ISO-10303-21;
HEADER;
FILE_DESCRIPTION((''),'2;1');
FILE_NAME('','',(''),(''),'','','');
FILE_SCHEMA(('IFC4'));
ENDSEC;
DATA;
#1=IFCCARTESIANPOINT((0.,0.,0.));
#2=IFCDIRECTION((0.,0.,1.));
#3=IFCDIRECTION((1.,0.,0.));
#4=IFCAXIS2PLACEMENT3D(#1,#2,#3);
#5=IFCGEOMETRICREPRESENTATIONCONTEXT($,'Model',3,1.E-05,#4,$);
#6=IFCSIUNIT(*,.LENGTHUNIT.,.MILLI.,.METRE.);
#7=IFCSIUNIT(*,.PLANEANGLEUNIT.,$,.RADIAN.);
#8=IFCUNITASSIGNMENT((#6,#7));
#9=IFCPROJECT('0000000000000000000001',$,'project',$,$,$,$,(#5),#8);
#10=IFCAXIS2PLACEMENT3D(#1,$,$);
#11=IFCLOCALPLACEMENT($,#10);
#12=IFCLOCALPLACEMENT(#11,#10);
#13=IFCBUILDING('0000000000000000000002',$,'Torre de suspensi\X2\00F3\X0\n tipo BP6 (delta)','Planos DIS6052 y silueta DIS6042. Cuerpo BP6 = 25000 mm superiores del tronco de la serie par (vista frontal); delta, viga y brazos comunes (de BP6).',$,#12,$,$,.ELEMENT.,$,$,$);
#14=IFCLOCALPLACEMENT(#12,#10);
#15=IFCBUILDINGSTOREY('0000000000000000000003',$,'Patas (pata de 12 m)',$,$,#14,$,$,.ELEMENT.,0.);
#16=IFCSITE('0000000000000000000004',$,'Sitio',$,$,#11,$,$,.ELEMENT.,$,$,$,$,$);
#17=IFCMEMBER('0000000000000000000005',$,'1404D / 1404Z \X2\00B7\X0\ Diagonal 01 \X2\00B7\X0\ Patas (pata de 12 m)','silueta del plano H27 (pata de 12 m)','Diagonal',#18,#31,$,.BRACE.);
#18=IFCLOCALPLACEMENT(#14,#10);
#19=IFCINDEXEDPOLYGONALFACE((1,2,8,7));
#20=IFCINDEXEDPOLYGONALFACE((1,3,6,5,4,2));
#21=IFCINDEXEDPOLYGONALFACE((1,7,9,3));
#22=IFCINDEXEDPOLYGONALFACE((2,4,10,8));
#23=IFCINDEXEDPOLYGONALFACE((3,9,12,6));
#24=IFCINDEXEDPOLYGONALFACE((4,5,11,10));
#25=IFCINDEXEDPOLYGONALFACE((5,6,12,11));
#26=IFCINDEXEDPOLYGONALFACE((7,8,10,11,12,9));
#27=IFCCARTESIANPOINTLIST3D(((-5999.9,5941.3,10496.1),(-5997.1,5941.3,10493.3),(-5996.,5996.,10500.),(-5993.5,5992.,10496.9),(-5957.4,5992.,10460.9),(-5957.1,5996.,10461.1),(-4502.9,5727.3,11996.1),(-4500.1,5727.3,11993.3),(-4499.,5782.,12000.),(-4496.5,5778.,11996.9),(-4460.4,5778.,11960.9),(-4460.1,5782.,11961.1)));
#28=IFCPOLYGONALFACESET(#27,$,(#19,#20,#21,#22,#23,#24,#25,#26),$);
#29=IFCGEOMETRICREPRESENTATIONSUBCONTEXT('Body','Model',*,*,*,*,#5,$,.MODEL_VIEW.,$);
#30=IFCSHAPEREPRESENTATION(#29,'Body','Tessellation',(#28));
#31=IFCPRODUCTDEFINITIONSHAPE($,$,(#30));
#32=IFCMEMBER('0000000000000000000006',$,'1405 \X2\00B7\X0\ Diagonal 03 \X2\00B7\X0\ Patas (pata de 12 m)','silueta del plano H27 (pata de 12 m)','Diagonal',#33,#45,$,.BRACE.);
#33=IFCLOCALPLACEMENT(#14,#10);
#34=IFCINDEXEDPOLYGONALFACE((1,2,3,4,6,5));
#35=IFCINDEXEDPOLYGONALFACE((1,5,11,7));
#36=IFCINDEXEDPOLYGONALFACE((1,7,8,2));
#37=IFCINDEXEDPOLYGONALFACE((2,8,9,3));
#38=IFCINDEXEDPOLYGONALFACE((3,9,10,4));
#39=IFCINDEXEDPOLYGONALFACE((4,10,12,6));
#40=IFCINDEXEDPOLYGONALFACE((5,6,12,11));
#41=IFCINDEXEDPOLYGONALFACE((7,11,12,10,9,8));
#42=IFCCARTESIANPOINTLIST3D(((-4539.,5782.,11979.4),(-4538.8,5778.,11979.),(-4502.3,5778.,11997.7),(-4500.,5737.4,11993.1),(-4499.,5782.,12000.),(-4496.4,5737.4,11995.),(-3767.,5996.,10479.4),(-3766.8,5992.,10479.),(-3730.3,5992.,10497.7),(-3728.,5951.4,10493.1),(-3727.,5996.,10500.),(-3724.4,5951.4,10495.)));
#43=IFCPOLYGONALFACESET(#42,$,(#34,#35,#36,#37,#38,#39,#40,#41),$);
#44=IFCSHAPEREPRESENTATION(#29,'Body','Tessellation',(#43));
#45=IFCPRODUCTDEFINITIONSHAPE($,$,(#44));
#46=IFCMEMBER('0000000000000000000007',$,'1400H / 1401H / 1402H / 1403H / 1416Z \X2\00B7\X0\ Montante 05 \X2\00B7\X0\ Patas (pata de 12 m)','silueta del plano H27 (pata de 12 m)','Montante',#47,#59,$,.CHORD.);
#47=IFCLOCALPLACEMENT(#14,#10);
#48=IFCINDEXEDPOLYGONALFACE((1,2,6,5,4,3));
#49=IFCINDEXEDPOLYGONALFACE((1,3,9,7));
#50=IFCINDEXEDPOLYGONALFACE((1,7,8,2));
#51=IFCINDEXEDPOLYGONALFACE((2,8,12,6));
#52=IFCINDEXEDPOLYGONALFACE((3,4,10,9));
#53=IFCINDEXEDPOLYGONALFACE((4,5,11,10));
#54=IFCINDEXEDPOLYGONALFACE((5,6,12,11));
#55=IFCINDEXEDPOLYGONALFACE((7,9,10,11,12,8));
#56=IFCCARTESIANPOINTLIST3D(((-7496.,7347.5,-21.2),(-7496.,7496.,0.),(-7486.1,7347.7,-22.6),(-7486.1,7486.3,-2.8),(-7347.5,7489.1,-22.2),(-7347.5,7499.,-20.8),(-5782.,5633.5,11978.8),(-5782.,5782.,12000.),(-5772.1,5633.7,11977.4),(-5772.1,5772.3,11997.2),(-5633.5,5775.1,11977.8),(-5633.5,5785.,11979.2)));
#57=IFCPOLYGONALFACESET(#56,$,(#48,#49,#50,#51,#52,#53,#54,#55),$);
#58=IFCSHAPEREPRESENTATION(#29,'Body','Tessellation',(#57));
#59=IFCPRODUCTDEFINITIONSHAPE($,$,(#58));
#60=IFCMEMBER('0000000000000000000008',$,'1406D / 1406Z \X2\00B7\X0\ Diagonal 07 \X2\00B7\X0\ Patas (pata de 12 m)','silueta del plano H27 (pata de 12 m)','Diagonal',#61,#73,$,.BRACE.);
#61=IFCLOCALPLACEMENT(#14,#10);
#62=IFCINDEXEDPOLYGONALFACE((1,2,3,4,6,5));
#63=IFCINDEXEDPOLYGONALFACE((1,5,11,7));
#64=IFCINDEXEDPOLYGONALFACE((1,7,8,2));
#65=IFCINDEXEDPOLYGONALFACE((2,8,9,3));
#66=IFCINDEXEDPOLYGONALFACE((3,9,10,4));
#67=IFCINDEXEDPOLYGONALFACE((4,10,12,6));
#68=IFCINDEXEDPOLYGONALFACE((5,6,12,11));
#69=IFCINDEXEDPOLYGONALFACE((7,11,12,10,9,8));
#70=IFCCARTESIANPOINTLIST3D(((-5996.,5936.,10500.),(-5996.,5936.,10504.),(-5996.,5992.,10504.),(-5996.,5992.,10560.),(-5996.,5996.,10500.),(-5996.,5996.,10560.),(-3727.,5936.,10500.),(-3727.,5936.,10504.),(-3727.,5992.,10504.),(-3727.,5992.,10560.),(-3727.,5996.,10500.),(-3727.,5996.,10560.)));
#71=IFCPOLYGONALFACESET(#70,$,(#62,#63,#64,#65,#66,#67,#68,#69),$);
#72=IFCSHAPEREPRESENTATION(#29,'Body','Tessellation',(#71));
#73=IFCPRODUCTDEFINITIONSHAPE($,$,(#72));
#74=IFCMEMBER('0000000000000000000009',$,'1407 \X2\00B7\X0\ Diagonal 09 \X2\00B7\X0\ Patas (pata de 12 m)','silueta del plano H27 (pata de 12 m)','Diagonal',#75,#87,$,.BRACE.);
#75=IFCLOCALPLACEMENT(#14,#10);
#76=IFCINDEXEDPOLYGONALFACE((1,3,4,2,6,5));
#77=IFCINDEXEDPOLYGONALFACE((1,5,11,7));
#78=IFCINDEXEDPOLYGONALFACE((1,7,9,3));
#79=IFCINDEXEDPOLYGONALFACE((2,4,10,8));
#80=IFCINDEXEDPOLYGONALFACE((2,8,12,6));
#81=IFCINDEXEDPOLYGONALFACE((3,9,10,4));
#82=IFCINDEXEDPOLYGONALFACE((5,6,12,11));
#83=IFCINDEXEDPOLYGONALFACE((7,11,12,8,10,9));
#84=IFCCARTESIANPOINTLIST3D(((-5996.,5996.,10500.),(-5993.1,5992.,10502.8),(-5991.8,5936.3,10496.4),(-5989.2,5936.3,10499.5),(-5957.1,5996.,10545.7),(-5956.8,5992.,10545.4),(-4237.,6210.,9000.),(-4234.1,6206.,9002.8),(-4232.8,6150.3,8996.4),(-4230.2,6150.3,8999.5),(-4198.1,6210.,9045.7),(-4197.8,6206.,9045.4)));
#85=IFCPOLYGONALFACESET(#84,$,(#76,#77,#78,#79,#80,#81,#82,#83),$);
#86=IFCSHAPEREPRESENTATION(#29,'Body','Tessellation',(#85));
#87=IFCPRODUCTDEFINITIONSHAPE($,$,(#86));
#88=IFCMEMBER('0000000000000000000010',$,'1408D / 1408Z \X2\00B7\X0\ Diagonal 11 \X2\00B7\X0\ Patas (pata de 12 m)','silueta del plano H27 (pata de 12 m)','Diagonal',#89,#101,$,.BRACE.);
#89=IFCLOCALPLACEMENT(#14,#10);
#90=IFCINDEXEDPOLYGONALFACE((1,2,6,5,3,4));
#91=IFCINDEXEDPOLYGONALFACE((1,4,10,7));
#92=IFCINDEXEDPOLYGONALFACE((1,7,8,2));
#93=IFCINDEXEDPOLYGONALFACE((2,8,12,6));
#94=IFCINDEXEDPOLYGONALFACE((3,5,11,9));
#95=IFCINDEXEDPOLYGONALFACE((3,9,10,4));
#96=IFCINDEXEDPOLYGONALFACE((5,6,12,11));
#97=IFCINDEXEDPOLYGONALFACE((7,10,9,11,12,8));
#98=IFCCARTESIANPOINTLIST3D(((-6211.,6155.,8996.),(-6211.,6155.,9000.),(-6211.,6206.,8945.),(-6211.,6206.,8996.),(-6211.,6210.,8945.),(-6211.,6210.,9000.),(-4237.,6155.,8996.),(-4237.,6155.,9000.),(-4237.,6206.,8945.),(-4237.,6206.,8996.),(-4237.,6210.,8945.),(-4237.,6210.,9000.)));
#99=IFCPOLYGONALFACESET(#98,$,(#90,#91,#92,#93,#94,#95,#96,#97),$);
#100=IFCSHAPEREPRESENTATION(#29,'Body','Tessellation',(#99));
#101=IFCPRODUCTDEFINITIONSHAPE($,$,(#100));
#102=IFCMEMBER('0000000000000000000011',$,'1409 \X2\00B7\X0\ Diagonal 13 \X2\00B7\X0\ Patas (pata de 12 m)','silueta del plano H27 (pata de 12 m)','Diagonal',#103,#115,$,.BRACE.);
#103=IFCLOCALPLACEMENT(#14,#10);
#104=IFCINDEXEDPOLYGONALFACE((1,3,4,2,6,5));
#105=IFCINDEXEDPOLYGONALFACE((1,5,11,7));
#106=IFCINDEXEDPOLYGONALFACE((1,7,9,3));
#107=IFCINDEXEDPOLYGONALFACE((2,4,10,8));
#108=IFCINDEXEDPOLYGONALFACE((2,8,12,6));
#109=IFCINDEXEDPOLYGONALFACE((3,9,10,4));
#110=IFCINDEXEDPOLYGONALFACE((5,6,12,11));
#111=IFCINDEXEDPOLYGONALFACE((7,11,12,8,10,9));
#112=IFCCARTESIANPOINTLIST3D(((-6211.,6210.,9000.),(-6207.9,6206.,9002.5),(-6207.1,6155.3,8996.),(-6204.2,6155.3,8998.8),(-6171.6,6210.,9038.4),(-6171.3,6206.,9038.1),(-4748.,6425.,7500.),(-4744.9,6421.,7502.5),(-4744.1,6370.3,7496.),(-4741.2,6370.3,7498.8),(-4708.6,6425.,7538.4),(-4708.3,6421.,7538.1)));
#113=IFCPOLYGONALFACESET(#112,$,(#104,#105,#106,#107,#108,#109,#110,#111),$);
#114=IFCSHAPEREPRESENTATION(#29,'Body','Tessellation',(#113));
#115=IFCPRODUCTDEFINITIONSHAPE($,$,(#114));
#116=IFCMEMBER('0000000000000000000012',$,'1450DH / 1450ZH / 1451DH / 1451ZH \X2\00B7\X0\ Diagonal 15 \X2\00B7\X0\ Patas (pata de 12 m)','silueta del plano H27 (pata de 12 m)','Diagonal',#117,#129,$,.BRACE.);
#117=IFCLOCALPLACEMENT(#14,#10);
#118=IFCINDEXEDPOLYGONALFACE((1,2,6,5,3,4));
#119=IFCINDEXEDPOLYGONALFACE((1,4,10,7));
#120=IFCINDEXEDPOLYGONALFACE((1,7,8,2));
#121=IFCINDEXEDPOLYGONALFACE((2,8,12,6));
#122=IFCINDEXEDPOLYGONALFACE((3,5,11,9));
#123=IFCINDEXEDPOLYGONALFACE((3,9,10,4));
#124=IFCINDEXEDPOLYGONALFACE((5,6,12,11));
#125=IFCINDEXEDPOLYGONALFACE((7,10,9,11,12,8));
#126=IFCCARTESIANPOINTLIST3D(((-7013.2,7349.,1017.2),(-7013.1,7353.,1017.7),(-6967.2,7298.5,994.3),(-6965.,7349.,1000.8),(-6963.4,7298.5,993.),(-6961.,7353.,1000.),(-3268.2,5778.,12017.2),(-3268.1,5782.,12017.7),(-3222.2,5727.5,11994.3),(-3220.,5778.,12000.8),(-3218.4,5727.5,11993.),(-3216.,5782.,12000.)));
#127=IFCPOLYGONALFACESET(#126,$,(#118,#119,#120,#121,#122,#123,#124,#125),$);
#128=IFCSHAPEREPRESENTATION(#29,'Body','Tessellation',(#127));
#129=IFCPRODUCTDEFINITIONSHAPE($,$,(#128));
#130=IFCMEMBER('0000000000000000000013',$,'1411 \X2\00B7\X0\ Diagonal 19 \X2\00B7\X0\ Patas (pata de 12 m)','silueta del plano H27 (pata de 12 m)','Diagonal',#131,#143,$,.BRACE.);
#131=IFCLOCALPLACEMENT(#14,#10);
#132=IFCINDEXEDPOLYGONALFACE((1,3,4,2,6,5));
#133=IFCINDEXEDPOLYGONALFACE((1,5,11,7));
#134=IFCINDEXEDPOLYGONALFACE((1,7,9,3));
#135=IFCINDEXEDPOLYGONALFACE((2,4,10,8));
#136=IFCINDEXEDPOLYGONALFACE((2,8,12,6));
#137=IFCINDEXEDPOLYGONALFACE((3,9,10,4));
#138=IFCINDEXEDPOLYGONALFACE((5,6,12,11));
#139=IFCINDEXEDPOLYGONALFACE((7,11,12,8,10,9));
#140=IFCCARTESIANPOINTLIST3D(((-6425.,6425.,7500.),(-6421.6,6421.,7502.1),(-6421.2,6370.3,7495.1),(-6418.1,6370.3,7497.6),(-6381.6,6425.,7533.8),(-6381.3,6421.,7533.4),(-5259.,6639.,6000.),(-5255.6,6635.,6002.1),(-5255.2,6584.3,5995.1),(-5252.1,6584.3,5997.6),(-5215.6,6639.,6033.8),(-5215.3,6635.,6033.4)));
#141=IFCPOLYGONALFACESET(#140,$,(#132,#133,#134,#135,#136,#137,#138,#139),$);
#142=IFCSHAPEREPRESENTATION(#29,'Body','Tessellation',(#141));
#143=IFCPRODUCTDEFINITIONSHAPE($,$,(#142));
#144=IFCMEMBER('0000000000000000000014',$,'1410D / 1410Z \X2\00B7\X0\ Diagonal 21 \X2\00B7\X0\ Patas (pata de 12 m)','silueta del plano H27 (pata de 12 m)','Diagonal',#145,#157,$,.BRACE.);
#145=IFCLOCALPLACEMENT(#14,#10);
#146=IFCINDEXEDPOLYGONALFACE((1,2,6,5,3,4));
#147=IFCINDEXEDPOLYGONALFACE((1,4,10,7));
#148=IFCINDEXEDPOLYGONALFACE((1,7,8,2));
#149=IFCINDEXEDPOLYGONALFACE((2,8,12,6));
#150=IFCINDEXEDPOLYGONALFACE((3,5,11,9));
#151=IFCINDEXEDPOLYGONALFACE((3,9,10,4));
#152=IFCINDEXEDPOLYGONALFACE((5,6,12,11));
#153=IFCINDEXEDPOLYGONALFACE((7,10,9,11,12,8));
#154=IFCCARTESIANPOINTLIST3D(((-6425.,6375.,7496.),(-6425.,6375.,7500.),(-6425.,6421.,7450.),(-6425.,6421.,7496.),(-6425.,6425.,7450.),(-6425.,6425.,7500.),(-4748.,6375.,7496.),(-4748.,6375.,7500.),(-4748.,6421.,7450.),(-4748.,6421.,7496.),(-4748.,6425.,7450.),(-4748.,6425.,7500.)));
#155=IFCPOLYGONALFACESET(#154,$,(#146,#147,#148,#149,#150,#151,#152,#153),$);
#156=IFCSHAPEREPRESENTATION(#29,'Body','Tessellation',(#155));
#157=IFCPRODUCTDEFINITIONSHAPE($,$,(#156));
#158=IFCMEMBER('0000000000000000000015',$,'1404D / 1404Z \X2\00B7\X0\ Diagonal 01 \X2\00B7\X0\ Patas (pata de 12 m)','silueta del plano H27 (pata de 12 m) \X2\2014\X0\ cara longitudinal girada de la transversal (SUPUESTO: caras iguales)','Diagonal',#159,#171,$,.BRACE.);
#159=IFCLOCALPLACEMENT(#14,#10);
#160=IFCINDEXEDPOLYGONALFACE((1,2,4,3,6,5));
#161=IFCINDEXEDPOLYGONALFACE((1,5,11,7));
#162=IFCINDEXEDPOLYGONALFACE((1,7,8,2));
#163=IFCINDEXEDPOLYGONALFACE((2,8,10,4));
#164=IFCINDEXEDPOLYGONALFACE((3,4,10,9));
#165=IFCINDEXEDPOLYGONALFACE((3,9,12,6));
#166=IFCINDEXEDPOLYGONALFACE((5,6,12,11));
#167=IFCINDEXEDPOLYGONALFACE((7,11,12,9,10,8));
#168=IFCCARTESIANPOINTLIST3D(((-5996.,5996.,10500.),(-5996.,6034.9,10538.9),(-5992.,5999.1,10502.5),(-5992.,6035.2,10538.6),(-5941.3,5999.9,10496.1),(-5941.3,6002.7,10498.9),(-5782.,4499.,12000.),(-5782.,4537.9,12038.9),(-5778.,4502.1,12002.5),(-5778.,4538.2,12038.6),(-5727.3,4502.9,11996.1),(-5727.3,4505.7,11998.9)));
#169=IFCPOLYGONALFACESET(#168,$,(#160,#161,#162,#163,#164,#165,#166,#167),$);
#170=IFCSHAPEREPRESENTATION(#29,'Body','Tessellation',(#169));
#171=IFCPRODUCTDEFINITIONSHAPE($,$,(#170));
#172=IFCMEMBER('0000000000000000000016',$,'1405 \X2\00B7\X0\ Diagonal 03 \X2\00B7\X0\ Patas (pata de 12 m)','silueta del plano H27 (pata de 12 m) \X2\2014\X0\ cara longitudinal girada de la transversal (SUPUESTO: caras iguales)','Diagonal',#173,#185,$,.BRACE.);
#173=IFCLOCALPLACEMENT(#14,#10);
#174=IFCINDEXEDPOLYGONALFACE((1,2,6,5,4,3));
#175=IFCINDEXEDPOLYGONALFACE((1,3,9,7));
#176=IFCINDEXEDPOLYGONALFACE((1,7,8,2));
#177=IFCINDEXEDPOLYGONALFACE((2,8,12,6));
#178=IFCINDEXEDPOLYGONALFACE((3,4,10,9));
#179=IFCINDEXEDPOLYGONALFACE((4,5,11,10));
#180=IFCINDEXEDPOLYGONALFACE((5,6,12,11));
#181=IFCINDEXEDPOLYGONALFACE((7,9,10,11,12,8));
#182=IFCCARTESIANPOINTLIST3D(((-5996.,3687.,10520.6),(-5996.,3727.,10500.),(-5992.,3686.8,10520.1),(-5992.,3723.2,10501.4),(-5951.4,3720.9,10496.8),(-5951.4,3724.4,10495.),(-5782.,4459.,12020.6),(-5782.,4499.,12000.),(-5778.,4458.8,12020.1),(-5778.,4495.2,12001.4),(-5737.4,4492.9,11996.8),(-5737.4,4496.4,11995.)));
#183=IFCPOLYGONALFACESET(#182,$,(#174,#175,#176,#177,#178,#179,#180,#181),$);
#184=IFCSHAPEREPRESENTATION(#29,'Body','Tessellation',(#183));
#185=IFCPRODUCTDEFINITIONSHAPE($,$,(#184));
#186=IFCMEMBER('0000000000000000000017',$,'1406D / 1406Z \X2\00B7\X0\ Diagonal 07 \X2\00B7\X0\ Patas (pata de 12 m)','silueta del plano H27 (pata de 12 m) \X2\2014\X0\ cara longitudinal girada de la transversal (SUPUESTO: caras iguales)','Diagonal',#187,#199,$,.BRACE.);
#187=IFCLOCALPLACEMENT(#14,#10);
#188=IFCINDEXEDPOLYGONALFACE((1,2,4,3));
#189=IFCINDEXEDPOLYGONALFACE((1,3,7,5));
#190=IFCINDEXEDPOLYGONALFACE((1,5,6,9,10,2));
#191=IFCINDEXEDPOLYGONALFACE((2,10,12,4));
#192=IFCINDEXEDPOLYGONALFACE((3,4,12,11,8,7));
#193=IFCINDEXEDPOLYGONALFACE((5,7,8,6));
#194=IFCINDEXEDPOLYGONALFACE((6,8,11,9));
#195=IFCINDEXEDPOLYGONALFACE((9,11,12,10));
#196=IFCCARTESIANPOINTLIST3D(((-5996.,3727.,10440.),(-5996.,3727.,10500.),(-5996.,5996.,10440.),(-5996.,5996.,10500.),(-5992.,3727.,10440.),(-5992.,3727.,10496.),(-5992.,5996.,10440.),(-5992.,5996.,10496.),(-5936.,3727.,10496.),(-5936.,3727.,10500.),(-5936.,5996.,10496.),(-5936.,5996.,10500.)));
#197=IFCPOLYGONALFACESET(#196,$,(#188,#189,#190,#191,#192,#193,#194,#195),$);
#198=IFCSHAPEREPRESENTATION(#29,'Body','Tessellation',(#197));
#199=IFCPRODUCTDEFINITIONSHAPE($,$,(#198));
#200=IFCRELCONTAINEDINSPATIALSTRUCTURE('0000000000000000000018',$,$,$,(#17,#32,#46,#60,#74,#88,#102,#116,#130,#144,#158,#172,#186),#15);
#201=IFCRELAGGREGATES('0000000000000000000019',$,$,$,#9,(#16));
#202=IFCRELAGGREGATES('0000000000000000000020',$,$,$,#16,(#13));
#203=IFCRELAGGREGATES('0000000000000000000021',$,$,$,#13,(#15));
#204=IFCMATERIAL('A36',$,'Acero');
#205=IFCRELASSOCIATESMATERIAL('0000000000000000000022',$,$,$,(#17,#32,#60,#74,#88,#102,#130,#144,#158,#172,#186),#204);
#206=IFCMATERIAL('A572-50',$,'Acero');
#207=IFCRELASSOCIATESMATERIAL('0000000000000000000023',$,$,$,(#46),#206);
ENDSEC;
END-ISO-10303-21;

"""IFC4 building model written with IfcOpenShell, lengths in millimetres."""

from ifc_helpers import new_model, si_unit, frame, frame_2d, origin, origin_with_axes, place, context, subcontext, project, spatial, l_section, extrude, material, element, save


model = new_model("IFC4")

# Units and contexts
model_context = context("Model", 3, precision=1e-05, world=origin_with_axes())
body_context = subcontext(model_context, "Body", "Model", "MODEL_VIEW")
ifc_project = project(units=[si_unit("LENGTHUNIT", "METRE", prefix="MILLI"), si_unit("PLANEANGLEUNIT", "RADIAN")], contexts=[model_context])

# Site, building, storey
site_placement = place(None, origin())
site = spatial("IfcSite", under=ifc_project, at=site_placement, Name="Sitio", CompositionType="ELEMENT")
building_placement = place(site_placement, origin())
building = spatial("IfcBuilding", under=site, at=building_placement, Name="Torre de suspensión tipo BP6 (delta)", Description="Planos DIS6052 y silueta DIS6042. Cuerpo BP6 = 25000 mm superiores del tronco de la serie par (vista frontal); delta, viga y brazos comunes (de BP6).", CompositionType="ELEMENT")
storey_placement = place(building_placement, origin())
storey = spatial("IfcBuildingStorey", under=building, at=storey_placement, Name="Patas (pata de 12 m)", CompositionType="ELEMENT", Elevation=0.0)

# Members
ifc_material_1 = material(Name="A36", Category="Acero")
member_1_placement = place(storey_placement, frame((-5996.0, 5996.0, 10500.0), z_axis=(0.702824, -0.100471, 0.704233), x_axis=(-0.070972, -0.99494, -0.071114)))
element("IfcMember", 1, at=member_1_placement, inside=storey, material=ifc_material_1, Name="1404D / 1404Z · Diagonal 01 · Patas (pata de 12 m)", Description="silueta del plano H27 (pata de 12 m)", ObjectType="Diagonal", PredefinedType="BRACE", context=body_context, shape_type="SweptSolid", body=[
    extrude(l_section(Depth=55.0, Width=55.0, Thickness=4.0, at=frame_2d((27.5, 27.5))), None, (0.0, 0.0, 1.0), 2130.0),
])
member_2_placement = place(storey_placement, frame((-4499.0, 5782.0, 12000.0), z_axis=(0.453978, 0.125844, -0.882081), x_axis=(0.057588, -0.99205, -0.111894)))
element("IfcMember", 2, at=member_2_placement, inside=storey, material=ifc_material_1, Name="1405 · Diagonal 03 · Patas (pata de 12 m)", Description="silueta del plano H27 (pata de 12 m)", ObjectType="Diagonal", PredefinedType="BRACE", context=body_context, shape_type="SweptSolid", body=[
    extrude(l_section(Depth=45.0, Width=45.0, Thickness=4.0, at=frame_2d((22.5, 22.5))), None, (0.0, 0.0, 1.0), 1700.5),
])
ifc_material_2 = material(Name="A572-50", Category="Acero")
member_3_placement = place(storey_placement, frame((-5782.0, 5782.0, 12000.0), z_axis=(-0.140006, 0.140006, -0.980202), x_axis=(0.990151, 0.019797, -0.138599)))
element("IfcMember", 3, at=member_3_placement, inside=storey, material=ifc_material_2, Name="1400H / 1401H / 1402H / 1403H / 1416Z · Montante 05 · Patas (pata de 12 m)", Description="silueta del plano H27 (pata de 12 m)", ObjectType="Montante", PredefinedType="CHORD", context=body_context, shape_type="SweptSolid", body=[
    extrude(l_section(Depth=150.0, Width=150.0, Thickness=10.0, at=frame_2d((75.0, 75.0))), None, (0.0, 0.0, 1.0), 12242.4),
])
member_4_placement = place(storey_placement, frame((-3727.0, 5996.0, 10500.0), z_axis=(-1.0, 0.0, 0.0), x_axis=(0.0, -1.0, 0.0)))
element("IfcMember", 4, at=member_4_placement, inside=storey, material=ifc_material_1, Name="1406D / 1406Z · Diagonal 07 · Patas (pata de 12 m)", Description="silueta del plano H27 (pata de 12 m)", ObjectType="Diagonal", PredefinedType="BRACE", context=body_context, shape_type="SweptSolid", body=[
    extrude(l_section(Depth=60.0, Width=60.0, Thickness=4.0, at=frame_2d((30.0, 30.0))), None, (0.0, 0.0, 1.0), 2269.0),
])
member_5_placement = place(storey_placement, frame((-4237.0, 6210.0, 9000.0), z_axis=(-0.757664, -0.092177, 0.646103), x_axis=(0.070138, -0.995743, -0.059811)))
element("IfcMember", 5, at=member_5_placement, inside=storey, material=ifc_material_1, Name="1407 · Diagonal 09 · Patas (pata de 12 m)", Description="silueta del plano H27 (pata de 12 m)", ObjectType="Diagonal", PredefinedType="BRACE", context=body_context, shape_type="SweptSolid", body=[
    extrude(l_section(Depth=60.0, Width=60.0, Thickness=4.0, at=frame_2d((30.0, 30.0))), None, (0.0, 0.0, 1.0), 2321.6),
])
member_6_placement = place(storey_placement, frame((-6211.0, 6210.0, 9000.0), z_axis=(1.0, 0.0, 0.0), x_axis=(0.0, -1.0, 0.0)))
element("IfcMember", 6, at=member_6_placement, inside=storey, material=ifc_material_1, Name="1408D / 1408Z · Diagonal 11 · Patas (pata de 12 m)", Description="silueta del plano H27 (pata de 12 m)", ObjectType="Diagonal", PredefinedType="BRACE", context=body_context, shape_type="SweptSolid", body=[
    extrude(l_section(Depth=55.0, Width=55.0, Thickness=4.0, at=frame_2d((27.5, 27.5))), None, (0.0, 0.0, 1.0), 1974.0),
])
member_7_placement = place(storey_placement, frame((-4748.0, 6425.0, 7500.0), z_axis=(-0.694576, -0.102074, 0.712142), x_axis=(0.07127, -0.994777, -0.073073)))
element("IfcMember", 7, at=member_7_placement, inside=storey, material=ifc_material_1, Name="1409 · Diagonal 13 · Patas (pata de 12 m)", Description="silueta del plano H27 (pata de 12 m)", ObjectType="Diagonal", PredefinedType="BRACE", context=body_context, shape_type="SweptSolid", body=[
    extrude(l_section(Depth=55.0, Width=55.0, Thickness=4.0, at=frame_2d((27.5, 27.5))), None, (0.0, 0.0, 1.0), 2106.3),
])
member_8_placement = place(storey_placement, frame((-3216.0, 5782.0, 12000.0), z_axis=(-0.319383, 0.133979, -0.938107), x_axis=(-0.04318, -0.990984, -0.12683)))
element("IfcMember", 8, at=member_8_placement, inside=storey, Name="1450DH / 1450ZH / 1451DH / 1451ZH · Diagonal 15 · Patas (pata de 12 m)", Description="silueta del plano H27 (pata de 12 m)", ObjectType="Diagonal", PredefinedType="BRACE", context=body_context, shape_type="SweptSolid", body=[
    extrude(l_section(Depth=55.0, Width=55.0, Thickness=4.0, at=frame_2d((27.5, 27.5))), None, (0.0, 0.0, 1.0), 11725.7),
])
member_9_placement = place(storey_placement, frame((-5259.0, 6639.0, 6000.0), z_axis=(-0.609865, -0.111931, 0.784561), x_axis=(0.068694, -0.993716, -0.088372)))
element("IfcMember", 9, at=member_9_placement, inside=storey, material=ifc_material_1, Name="1411 · Diagonal 19 · Patas (pata de 12 m)", Description="silueta del plano H27 (pata de 12 m)", ObjectType="Diagonal", PredefinedType="BRACE", context=body_context, shape_type="SweptSolid", body=[
    extrude(l_section(Depth=55.0, Width=55.0, Thickness=4.0, at=frame_2d((27.5, 27.5))), None, (0.0, 0.0, 1.0), 1911.9),
])
member_10_placement = place(storey_placement, frame((-6425.0, 6425.0, 7500.0), z_axis=(1.0, 0.0, 0.0), x_axis=(0.0, -1.0, 0.0)))
element("IfcMember", 10, at=member_10_placement, inside=storey, material=ifc_material_1, Name="1410D / 1410Z · Diagonal 21 · Patas (pata de 12 m)", Description="silueta del plano H27 (pata de 12 m)", ObjectType="Diagonal", PredefinedType="BRACE", context=body_context, shape_type="SweptSolid", body=[
    extrude(l_section(Depth=50.0, Width=50.0, Thickness=4.0, at=frame_2d((25.0, 25.0))), None, (0.0, 0.0, 1.0), 1677.0),
])
member_11_placement = place(storey_placement, frame((-5996.0, 5996.0, 10500.0), z_axis=(0.100471, -0.702824, 0.704233), x_axis=(0.99494, 0.070972, -0.071114)))
element("IfcMember", 11, at=member_11_placement, inside=storey, material=ifc_material_1, Name="1404D / 1404Z · Diagonal 01 · Patas (pata de 12 m)", Description="silueta del plano H27 (pata de 12 m) — cara longitudinal girada de la transversal (SUPUESTO: caras iguales)", ObjectType="Diagonal", PredefinedType="BRACE", context=body_context, shape_type="SweptSolid", body=[
    extrude(l_section(Depth=55.0, Width=55.0, Thickness=4.0, at=frame_2d((27.5, 27.5))), None, (0.0, 0.0, 1.0), 2130.0),
])
member_12_placement = place(storey_placement, frame((-5782.0, 4499.0, 12000.0), z_axis=(-0.125844, -0.453978, -0.882081), x_axis=(0.99205, -0.057588, -0.111894)))
element("IfcMember", 12, at=member_12_placement, inside=storey, material=ifc_material_1, Name="1405 · Diagonal 03 · Patas (pata de 12 m)", Description="silueta del plano H27 (pata de 12 m) — cara longitudinal girada de la transversal (SUPUESTO: caras iguales)", ObjectType="Diagonal", PredefinedType="BRACE", context=body_context, shape_type="SweptSolid", body=[
    extrude(l_section(Depth=45.0, Width=45.0, Thickness=4.0, at=frame_2d((22.5, 22.5))), None, (0.0, 0.0, 1.0), 1700.5),
])
member_13_placement = place(storey_placement, frame((-5996.0, 3727.0, 10500.0), z_axis=(0.0, 1.0, 0.0), x_axis=(1.0, 0.0, 0.0)))
element("IfcMember", 13, at=member_13_placement, inside=storey, material=ifc_material_1, Name="1406D / 1406Z · Diagonal 07 · Patas (pata de 12 m)", Description="silueta del plano H27 (pata de 12 m) — cara longitudinal girada de la transversal (SUPUESTO: caras iguales)", ObjectType="Diagonal", PredefinedType="BRACE", context=body_context, shape_type="SweptSolid", body=[
    extrude(l_section(Depth=60.0, Width=60.0, Thickness=4.0, at=frame_2d((30.0, 30.0))), None, (0.0, 0.0, 1.0), 2269.0),
])

save(model, "model.ifc")
